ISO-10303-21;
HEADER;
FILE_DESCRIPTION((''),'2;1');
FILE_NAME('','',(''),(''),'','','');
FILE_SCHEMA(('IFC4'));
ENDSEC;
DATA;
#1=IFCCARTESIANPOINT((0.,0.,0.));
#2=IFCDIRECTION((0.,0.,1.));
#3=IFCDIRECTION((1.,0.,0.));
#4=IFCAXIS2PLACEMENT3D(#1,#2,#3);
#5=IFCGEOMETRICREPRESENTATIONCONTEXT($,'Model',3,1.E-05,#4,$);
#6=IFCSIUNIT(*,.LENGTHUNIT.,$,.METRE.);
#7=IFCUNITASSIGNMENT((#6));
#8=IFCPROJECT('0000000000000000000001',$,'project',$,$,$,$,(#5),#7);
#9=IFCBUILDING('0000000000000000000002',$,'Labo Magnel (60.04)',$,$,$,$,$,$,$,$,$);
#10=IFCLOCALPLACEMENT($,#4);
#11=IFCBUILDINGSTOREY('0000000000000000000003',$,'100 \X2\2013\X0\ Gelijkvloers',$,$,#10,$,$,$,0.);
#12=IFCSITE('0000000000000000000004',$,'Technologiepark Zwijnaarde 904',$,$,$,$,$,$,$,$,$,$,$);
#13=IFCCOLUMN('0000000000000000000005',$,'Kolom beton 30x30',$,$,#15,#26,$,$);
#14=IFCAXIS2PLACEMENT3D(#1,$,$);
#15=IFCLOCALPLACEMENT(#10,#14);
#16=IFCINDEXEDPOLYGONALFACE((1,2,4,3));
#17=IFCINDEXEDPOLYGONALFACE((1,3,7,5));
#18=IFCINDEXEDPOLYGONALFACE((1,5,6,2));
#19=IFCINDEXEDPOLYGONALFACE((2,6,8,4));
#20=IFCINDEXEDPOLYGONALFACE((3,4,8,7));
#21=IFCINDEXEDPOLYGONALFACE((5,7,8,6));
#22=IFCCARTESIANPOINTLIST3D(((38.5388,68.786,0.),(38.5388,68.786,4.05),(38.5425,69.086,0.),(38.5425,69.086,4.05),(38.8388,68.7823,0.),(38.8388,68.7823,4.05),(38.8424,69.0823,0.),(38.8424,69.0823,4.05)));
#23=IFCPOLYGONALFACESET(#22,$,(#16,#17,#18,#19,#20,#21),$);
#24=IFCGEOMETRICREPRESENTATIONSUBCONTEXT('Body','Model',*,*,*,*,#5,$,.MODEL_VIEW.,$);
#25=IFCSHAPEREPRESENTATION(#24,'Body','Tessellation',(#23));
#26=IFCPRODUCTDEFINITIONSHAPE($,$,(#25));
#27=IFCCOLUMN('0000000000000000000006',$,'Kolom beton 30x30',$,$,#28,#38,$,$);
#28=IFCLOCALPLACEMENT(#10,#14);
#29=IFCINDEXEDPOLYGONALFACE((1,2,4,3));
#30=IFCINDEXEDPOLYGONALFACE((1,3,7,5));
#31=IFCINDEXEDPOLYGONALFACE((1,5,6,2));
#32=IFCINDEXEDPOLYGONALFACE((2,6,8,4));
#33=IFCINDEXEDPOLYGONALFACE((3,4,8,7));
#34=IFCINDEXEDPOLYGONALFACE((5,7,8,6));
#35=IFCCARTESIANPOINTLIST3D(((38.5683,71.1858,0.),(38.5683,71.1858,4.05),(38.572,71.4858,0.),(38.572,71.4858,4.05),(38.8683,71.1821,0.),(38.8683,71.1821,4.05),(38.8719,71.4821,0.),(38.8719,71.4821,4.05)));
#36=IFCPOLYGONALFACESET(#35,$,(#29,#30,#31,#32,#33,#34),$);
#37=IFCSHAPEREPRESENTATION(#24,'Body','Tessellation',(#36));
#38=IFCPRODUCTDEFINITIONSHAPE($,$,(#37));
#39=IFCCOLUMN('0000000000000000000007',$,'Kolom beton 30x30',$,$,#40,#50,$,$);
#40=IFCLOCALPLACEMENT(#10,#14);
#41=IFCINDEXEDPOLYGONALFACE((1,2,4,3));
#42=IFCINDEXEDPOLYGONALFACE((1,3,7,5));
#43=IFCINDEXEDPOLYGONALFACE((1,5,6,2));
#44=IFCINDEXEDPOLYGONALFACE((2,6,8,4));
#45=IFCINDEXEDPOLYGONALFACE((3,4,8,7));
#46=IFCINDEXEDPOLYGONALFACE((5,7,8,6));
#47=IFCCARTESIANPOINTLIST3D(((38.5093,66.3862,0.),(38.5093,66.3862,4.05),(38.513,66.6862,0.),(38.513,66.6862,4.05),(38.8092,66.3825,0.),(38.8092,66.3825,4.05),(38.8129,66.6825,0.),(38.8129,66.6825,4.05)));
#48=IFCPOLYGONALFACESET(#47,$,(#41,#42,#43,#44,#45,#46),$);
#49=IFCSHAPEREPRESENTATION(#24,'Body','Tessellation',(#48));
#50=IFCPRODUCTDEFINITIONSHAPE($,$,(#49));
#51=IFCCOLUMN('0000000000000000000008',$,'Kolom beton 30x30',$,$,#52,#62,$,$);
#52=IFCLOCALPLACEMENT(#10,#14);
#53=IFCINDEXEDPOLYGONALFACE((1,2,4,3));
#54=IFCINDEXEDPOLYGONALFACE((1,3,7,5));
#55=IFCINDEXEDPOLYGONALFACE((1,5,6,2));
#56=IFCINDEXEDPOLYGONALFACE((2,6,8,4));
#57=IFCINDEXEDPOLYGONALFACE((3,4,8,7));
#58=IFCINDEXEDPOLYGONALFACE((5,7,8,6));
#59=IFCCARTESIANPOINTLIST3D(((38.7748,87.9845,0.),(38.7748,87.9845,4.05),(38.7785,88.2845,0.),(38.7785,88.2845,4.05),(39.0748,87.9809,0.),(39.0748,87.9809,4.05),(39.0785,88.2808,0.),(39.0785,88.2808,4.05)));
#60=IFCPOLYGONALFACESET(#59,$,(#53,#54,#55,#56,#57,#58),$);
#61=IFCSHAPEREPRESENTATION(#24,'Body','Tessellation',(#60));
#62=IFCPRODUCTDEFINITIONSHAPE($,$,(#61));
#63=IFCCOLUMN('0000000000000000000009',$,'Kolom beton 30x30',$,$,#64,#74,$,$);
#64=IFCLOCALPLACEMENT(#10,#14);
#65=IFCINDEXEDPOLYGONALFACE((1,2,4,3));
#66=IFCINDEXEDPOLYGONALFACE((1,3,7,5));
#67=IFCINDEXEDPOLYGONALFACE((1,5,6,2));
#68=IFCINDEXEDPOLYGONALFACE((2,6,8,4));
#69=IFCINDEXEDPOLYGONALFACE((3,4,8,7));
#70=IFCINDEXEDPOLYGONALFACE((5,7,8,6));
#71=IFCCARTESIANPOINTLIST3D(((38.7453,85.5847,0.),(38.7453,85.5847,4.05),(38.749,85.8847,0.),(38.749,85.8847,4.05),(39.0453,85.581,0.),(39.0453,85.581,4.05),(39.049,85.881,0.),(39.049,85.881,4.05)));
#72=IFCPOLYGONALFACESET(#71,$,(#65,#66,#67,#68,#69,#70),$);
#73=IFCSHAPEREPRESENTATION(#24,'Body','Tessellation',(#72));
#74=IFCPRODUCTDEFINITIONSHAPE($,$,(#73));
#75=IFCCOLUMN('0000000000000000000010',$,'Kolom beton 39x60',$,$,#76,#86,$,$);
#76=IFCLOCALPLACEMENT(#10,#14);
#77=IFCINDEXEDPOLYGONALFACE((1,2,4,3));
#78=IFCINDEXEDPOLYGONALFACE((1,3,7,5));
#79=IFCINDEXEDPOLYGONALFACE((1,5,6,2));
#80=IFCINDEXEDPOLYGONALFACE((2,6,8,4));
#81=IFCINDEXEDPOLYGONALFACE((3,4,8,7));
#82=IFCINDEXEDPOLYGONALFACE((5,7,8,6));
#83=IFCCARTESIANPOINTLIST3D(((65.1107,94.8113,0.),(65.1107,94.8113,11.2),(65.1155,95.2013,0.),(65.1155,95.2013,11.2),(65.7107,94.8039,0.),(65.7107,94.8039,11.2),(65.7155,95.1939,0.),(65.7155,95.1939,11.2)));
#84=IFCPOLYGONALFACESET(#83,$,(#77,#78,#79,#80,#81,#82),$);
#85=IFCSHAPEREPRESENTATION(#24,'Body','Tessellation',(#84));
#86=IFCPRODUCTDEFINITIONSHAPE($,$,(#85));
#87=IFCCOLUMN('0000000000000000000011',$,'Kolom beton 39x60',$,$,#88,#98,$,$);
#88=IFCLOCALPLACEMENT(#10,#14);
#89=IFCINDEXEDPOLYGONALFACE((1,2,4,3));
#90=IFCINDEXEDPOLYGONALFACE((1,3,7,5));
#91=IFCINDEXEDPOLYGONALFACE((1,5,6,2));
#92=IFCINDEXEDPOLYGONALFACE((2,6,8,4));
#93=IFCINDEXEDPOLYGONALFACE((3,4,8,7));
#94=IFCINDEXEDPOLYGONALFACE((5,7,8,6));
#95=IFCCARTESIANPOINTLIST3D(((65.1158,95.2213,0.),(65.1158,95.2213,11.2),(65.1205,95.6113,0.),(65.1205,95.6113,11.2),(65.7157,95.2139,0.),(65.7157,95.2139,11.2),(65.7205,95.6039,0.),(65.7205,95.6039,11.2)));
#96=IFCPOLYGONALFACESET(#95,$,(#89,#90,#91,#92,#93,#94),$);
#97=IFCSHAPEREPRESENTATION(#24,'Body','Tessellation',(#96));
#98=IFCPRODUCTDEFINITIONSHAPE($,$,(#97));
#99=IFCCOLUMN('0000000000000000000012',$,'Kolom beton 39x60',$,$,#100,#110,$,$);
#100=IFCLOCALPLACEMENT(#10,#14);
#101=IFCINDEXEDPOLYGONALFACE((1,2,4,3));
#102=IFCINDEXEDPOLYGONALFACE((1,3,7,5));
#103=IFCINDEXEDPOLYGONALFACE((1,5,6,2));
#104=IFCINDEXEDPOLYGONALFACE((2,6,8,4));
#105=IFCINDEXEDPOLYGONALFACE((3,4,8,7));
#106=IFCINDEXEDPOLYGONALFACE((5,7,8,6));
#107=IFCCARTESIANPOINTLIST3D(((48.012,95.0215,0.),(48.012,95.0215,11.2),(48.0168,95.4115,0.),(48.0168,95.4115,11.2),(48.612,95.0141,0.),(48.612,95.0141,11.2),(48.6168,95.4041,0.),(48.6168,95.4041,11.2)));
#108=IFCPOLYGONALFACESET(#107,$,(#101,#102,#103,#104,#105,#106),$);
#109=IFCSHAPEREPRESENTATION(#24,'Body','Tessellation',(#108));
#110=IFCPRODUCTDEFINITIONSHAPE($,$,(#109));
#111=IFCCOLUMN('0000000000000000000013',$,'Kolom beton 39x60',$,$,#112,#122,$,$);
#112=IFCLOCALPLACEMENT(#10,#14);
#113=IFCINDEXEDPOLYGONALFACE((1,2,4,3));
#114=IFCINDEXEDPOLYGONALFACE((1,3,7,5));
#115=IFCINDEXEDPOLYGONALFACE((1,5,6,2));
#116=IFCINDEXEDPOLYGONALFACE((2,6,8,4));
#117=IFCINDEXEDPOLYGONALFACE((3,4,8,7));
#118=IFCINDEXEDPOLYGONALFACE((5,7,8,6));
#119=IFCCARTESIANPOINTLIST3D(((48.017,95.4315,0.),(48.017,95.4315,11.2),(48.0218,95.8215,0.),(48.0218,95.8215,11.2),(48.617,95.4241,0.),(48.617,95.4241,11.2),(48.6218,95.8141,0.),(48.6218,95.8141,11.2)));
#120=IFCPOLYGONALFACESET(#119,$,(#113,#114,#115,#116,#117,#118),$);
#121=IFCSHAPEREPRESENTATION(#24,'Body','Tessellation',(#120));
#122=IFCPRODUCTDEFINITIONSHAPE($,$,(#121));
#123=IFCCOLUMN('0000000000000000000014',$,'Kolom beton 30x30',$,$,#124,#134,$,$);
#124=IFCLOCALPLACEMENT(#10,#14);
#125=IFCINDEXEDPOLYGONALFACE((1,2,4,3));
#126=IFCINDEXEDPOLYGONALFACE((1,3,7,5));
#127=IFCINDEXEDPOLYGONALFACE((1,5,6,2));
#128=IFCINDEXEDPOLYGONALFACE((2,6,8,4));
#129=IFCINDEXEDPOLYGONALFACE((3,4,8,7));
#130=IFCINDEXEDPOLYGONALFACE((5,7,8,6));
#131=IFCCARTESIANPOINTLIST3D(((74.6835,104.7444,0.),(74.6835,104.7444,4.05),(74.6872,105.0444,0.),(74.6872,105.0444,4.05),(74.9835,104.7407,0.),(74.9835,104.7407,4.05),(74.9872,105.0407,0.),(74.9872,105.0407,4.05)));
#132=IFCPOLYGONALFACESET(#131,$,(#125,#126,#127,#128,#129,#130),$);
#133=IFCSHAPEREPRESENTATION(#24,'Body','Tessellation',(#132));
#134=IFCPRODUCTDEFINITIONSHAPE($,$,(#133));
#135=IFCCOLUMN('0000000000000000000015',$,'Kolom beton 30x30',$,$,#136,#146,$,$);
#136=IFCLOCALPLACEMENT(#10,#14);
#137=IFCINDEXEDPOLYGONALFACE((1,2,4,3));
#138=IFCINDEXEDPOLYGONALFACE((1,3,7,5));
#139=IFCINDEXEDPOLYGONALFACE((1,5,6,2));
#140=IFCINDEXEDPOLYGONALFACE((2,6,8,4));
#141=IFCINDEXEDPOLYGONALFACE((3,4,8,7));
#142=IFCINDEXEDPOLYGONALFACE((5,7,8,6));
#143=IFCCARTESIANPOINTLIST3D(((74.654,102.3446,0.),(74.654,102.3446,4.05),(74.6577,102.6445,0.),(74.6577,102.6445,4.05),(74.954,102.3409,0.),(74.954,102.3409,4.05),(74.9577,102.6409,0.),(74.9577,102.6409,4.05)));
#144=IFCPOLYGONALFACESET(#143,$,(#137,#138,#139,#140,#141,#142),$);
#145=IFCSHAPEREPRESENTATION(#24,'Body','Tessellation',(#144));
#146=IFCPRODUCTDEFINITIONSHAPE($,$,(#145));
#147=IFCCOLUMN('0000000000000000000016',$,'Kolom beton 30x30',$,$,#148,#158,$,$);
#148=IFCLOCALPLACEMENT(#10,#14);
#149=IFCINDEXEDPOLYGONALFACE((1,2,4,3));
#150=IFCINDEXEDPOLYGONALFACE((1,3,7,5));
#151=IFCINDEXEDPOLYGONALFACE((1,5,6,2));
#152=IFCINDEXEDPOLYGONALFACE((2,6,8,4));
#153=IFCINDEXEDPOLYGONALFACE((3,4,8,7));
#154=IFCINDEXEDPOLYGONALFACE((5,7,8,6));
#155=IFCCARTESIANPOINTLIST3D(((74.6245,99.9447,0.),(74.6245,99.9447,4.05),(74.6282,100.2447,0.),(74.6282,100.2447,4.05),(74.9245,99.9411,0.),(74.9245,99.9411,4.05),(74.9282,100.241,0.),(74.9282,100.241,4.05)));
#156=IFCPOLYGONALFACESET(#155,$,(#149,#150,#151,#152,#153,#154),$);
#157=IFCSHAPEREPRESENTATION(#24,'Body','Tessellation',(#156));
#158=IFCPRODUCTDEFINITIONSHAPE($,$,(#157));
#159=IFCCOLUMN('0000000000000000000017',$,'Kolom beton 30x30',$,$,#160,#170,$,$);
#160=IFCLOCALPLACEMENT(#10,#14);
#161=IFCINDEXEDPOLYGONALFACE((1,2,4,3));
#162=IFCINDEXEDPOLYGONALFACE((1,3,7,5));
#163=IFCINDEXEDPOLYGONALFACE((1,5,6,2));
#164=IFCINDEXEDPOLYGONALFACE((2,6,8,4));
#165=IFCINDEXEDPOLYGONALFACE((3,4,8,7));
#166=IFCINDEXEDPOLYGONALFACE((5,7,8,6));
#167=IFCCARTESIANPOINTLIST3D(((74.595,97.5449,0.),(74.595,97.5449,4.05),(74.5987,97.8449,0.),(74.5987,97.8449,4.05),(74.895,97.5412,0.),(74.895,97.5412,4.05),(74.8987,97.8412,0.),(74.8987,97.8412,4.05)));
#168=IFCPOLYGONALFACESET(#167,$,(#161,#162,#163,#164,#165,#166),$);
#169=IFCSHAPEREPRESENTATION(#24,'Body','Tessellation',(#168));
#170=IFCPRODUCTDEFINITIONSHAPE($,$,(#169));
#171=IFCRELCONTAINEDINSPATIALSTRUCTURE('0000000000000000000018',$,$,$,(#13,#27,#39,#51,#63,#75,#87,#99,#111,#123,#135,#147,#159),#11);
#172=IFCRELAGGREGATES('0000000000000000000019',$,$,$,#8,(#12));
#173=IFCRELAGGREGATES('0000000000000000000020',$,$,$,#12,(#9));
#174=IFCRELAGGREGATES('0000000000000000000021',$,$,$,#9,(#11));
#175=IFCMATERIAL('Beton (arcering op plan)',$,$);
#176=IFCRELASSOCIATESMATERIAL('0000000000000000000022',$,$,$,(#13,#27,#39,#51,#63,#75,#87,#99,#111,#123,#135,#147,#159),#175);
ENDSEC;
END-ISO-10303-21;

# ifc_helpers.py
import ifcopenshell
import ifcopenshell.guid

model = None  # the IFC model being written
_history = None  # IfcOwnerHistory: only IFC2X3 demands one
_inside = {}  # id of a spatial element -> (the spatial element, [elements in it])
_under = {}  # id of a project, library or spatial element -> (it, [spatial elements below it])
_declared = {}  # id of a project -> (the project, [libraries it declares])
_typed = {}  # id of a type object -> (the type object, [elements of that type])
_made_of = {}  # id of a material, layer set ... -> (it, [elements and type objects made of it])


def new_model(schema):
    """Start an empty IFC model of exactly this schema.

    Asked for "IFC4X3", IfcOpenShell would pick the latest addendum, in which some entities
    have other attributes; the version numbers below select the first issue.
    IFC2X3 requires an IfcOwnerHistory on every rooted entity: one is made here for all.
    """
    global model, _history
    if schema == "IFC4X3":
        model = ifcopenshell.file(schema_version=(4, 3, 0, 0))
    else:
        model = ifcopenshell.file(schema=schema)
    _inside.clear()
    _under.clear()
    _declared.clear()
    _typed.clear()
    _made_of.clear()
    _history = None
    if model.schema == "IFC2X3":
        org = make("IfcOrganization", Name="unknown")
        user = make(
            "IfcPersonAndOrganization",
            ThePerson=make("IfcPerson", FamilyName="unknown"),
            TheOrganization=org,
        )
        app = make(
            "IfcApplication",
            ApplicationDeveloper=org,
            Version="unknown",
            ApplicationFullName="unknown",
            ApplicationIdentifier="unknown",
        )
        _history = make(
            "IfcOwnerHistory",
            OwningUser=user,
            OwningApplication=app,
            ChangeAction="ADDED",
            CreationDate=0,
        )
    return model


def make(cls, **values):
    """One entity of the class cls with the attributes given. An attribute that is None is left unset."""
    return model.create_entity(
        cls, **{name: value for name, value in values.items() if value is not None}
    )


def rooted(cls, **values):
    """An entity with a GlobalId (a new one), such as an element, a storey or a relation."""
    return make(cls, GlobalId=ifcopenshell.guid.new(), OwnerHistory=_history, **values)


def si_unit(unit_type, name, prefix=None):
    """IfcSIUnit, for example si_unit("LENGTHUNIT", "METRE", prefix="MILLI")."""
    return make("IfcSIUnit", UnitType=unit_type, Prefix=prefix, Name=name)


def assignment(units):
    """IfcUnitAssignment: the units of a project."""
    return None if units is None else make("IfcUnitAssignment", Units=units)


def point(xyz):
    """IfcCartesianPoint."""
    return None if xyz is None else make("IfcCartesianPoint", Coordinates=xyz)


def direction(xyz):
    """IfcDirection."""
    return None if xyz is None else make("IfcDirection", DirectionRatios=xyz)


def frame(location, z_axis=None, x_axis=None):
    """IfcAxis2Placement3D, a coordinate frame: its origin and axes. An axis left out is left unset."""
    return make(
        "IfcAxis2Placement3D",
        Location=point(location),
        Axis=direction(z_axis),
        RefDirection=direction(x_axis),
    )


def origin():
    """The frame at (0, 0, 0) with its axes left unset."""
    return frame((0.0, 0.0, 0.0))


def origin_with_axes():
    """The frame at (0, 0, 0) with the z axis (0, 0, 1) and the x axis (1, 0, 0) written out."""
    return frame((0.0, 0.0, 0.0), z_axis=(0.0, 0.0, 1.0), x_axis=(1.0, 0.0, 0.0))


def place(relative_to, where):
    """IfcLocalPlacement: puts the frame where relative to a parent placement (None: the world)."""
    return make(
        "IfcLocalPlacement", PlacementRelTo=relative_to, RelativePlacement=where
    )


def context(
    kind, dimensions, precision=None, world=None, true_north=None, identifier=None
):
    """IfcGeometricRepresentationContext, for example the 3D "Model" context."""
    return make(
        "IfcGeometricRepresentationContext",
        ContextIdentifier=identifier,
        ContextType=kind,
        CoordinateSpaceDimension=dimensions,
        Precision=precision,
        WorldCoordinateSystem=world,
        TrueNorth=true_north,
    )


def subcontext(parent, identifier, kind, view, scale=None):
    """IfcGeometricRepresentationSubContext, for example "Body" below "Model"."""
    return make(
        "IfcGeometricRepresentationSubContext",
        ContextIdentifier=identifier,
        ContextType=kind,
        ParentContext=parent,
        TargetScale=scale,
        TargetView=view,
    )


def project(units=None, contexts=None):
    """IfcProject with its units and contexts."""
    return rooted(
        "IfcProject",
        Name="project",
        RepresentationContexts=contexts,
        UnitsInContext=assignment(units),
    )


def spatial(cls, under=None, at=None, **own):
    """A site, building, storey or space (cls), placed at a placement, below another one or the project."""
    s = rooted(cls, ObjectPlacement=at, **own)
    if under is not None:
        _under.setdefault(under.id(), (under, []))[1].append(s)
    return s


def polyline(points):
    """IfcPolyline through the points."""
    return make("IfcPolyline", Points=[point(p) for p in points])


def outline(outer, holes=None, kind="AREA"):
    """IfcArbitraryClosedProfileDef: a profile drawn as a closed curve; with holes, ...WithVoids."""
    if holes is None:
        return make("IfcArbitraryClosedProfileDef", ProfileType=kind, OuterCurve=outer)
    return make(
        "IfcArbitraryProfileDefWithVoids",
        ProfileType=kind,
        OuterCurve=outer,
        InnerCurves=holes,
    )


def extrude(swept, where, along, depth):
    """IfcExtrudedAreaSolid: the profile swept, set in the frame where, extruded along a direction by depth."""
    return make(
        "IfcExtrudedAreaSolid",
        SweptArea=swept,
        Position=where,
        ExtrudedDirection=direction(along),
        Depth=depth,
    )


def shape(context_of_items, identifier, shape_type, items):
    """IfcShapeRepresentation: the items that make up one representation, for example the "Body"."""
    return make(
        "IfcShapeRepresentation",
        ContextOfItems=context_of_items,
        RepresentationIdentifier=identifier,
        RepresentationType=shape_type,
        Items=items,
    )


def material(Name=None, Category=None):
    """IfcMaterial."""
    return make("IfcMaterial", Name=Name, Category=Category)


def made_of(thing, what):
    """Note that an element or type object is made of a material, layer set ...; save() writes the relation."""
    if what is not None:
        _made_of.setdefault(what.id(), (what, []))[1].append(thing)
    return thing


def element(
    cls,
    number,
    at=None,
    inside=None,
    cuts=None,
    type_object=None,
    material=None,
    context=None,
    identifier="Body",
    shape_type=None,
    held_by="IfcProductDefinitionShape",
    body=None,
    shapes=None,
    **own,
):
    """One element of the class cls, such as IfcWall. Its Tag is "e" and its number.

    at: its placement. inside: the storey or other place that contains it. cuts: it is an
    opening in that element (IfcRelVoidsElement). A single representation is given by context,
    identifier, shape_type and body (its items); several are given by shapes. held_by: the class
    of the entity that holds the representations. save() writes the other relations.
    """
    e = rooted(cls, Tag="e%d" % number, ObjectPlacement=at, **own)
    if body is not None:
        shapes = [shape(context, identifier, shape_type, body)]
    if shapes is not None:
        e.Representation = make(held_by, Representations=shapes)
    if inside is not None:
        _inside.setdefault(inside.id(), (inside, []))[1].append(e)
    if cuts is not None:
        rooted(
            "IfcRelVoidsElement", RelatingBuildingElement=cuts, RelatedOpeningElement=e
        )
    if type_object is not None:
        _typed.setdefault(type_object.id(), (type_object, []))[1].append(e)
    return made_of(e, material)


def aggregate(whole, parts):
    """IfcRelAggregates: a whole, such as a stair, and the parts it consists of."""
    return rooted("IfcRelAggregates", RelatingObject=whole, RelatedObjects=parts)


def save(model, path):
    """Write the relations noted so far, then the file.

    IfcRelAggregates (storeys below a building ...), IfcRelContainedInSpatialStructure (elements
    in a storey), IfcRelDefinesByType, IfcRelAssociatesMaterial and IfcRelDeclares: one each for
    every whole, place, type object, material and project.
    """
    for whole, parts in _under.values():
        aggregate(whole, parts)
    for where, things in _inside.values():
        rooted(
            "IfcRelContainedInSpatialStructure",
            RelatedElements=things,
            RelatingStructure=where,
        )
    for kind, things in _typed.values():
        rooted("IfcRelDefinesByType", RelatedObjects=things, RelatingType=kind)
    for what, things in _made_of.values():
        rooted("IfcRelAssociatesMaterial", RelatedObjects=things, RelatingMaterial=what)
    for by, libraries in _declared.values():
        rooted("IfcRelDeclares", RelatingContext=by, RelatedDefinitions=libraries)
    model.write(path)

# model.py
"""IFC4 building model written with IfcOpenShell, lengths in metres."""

from ifc_helpers import new_model, si_unit, origin, origin_with_axes, place, context, subcontext, project, spatial, polyline, outline, extrude, material, element, save


model = new_model("IFC4")

# Units and contexts
model_context = context("Model", 3, precision=1e-05, world=origin_with_axes())
body_context = subcontext(model_context, "Body", "Model", "MODEL_VIEW")
ifc_project = project(units=[si_unit("LENGTHUNIT", "METRE")], contexts=[model_context])

# Site, building, storey
site = spatial("IfcSite", under=ifc_project, Name="Technologiepark Zwijnaarde 904")
building = spatial("IfcBuilding", under=site, Name="Labo Magnel (60.04)")
storey_placement = place(None, origin_with_axes())
storey = spatial("IfcBuildingStorey", under=building, at=storey_placement, Name="100 – Gelijkvloers", Elevation=0.0)

# Columns
ifc_material = material(Name="Beton (arcering op plan)")
column_1_placement = place(storey_placement, origin_with_axes())
element("IfcColumn", 1, at=column_1_placement, inside=storey, material=ifc_material, Name="Kolom beton 30x30", context=body_context, shape_type="SweptSolid", body=[
    extrude(outline(polyline([(38.8424, 69.0823), (38.5425, 69.086), (38.5388, 68.786), (38.8388, 68.7823), (38.8424, 69.0823)])), origin(), (0.0, 0.0, 1.0), 4.05),
])
column_2_placement = place(storey_placement, origin_with_axes())
element("IfcColumn", 2, at=column_2_placement, inside=storey, material=ifc_material, Name="Kolom beton 30x30", context=body_context, shape_type="SweptSolid", body=[
    extrude(outline(polyline([(38.8719, 71.4821), (38.572, 71.4858), (38.5683, 71.1858), (38.8683, 71.1821), (38.8719, 71.4821)])), origin(), (0.0, 0.0, 1.0), 4.05),
])
column_3_placement = place(storey_placement, origin_with_axes())
element("IfcColumn", 3, at=column_3_placement, inside=storey, material=ifc_material, Name="Kolom beton 30x30", context=body_context, shape_type="SweptSolid", body=[
    extrude(outline(polyline([(38.8129, 66.6825), (38.513, 66.6862), (38.5093, 66.3862), (38.8092, 66.3825), (38.8129, 66.6825)])), origin(), (0.0, 0.0, 1.0), 4.05),
])
column_4_placement = place(storey_placement, origin_with_axes())
element("IfcColumn", 4, at=column_4_placement, inside=storey, material=ifc_material, Name="Kolom beton 30x30", context=body_context, shape_type="SweptSolid", body=[
    extrude(outline(polyline([(39.0785, 88.2808), (38.7785, 88.2845), (38.7748, 87.9845), (39.0748, 87.9809), (39.0785, 88.2808)])), origin(), (0.0, 0.0, 1.0), 4.05),
])
column_5_placement = place(storey_placement, origin_with_axes())
element("IfcColumn", 5, at=column_5_placement, inside=storey, material=ifc_material, Name="Kolom beton 30x30", context=body_context, shape_type="SweptSolid", body=[
    extrude(outline(polyline([(39.049, 85.881), (38.749, 85.8847), (38.7453, 85.5847), (39.0453, 85.581), (39.049, 85.881)])), origin(), (0.0, 0.0, 1.0), 4.05),
])
column_6_placement = place(storey_placement, origin_with_axes())
element("IfcColumn", 6, at=column_6_placement, inside=storey, material=ifc_material, Name="Kolom beton 39x60", context=body_context, shape_type="SweptSolid", body=[
    extrude(outline(polyline([(65.7155, 95.1939), (65.1155, 95.2013), (65.1107, 94.8113), (65.7107, 94.8039), (65.7155, 95.1939)])), origin(), (0.0, 0.0, 1.0), 11.2),
])
column_7_placement = place(storey_placement, origin_with_axes())
element("IfcColumn", 7, at=column_7_placement, inside=storey, material=ifc_material, Name="Kolom beton 39x60", context=body_context, shape_type="SweptSolid", body=[
    extrude(outline(polyline([(65.7205, 95.6039), (65.1205, 95.6113), (65.1158, 95.2213), (65.7157, 95.2139), (65.7205, 95.6039)])), origin(), (0.0, 0.0, 1.0), 11.2),
])
column_8_placement = place(storey_placement, origin_with_axes())
element("IfcColumn", 8, at=column_8_placement, inside=storey, material=ifc_material, Name="Kolom beton 39x60", context=body_context, shape_type="SweptSolid", body=[
    extrude(outline(polyline([(48.6168, 95.4041), (48.0168, 95.4115), (48.012, 95.0215), (48.612, 95.0141), (48.6168, 95.4041)])), origin(), (0.0, 0.0, 1.0), 11.2),
])
column_9_placement = place(storey_placement, origin_with_axes())
element("IfcColumn", 9, at=column_9_placement, inside=storey, material=ifc_material, Name="Kolom beton 39x60", context=body_context, shape_type="SweptSolid", body=[
    extrude(outline(polyline([(48.6218, 95.8141), (48.0218, 95.8215), (48.017, 95.4315), (48.617, 95.4241), (48.6218, 95.8141)])), origin(), (0.0, 0.0, 1.0), 11.2),
])
column_10_placement = place(storey_placement, origin_with_axes())
element("IfcColumn", 10, at=column_10_placement, inside=storey, material=ifc_material, Name="Kolom beton 30x30", context=body_context, shape_type="SweptSolid", body=[
    extrude(outline(polyline([(74.9872, 105.0407), (74.6872, 105.0444), (74.6835, 104.7444), (74.9835, 104.7407), (74.9872, 105.0407)])), origin(), (0.0, 0.0, 1.0), 4.05),
])
column_11_placement = place(storey_placement, origin_with_axes())
element("IfcColumn", 11, at=column_11_placement, inside=storey, material=ifc_material, Name="Kolom beton 30x30", context=body_context, shape_type="SweptSolid", body=[
    extrude(outline(polyline([(74.9577, 102.6409), (74.6577, 102.6445), (74.654, 102.3446), (74.954, 102.3409), (74.9577, 102.6409)])), origin(), (0.0, 0.0, 1.0), 4.05),
])
column_12_placement = place(storey_placement, origin_with_axes())
element("IfcColumn", 12, at=column_12_placement, inside=storey, material=ifc_material, Name="Kolom beton 30x30", context=body_context, shape_type="SweptSolid", body=[
    extrude(outline(polyline([(74.9282, 100.241), (74.6282, 100.2447), (74.6245, 99.9447), (74.9245, 99.9411), (74.9282, 100.241)])), origin(), (0.0, 0.0, 1.0), 4.05),
])
column_13_placement = place(storey_placement, origin_with_axes())
element("IfcColumn", 13, at=column_13_placement, inside=storey, material=ifc_material, Name="Kolom beton 30x30", context=body_context, shape_type="SweptSolid", body=[
    extrude(outline(polyline([(74.8987, 97.8412), (74.5987, 97.8449), (74.595, 97.5449), (74.895, 97.5412), (74.8987, 97.8412)])), origin(), (0.0, 0.0, 1.0), 4.05),
])

save(model, "model.ifc")
